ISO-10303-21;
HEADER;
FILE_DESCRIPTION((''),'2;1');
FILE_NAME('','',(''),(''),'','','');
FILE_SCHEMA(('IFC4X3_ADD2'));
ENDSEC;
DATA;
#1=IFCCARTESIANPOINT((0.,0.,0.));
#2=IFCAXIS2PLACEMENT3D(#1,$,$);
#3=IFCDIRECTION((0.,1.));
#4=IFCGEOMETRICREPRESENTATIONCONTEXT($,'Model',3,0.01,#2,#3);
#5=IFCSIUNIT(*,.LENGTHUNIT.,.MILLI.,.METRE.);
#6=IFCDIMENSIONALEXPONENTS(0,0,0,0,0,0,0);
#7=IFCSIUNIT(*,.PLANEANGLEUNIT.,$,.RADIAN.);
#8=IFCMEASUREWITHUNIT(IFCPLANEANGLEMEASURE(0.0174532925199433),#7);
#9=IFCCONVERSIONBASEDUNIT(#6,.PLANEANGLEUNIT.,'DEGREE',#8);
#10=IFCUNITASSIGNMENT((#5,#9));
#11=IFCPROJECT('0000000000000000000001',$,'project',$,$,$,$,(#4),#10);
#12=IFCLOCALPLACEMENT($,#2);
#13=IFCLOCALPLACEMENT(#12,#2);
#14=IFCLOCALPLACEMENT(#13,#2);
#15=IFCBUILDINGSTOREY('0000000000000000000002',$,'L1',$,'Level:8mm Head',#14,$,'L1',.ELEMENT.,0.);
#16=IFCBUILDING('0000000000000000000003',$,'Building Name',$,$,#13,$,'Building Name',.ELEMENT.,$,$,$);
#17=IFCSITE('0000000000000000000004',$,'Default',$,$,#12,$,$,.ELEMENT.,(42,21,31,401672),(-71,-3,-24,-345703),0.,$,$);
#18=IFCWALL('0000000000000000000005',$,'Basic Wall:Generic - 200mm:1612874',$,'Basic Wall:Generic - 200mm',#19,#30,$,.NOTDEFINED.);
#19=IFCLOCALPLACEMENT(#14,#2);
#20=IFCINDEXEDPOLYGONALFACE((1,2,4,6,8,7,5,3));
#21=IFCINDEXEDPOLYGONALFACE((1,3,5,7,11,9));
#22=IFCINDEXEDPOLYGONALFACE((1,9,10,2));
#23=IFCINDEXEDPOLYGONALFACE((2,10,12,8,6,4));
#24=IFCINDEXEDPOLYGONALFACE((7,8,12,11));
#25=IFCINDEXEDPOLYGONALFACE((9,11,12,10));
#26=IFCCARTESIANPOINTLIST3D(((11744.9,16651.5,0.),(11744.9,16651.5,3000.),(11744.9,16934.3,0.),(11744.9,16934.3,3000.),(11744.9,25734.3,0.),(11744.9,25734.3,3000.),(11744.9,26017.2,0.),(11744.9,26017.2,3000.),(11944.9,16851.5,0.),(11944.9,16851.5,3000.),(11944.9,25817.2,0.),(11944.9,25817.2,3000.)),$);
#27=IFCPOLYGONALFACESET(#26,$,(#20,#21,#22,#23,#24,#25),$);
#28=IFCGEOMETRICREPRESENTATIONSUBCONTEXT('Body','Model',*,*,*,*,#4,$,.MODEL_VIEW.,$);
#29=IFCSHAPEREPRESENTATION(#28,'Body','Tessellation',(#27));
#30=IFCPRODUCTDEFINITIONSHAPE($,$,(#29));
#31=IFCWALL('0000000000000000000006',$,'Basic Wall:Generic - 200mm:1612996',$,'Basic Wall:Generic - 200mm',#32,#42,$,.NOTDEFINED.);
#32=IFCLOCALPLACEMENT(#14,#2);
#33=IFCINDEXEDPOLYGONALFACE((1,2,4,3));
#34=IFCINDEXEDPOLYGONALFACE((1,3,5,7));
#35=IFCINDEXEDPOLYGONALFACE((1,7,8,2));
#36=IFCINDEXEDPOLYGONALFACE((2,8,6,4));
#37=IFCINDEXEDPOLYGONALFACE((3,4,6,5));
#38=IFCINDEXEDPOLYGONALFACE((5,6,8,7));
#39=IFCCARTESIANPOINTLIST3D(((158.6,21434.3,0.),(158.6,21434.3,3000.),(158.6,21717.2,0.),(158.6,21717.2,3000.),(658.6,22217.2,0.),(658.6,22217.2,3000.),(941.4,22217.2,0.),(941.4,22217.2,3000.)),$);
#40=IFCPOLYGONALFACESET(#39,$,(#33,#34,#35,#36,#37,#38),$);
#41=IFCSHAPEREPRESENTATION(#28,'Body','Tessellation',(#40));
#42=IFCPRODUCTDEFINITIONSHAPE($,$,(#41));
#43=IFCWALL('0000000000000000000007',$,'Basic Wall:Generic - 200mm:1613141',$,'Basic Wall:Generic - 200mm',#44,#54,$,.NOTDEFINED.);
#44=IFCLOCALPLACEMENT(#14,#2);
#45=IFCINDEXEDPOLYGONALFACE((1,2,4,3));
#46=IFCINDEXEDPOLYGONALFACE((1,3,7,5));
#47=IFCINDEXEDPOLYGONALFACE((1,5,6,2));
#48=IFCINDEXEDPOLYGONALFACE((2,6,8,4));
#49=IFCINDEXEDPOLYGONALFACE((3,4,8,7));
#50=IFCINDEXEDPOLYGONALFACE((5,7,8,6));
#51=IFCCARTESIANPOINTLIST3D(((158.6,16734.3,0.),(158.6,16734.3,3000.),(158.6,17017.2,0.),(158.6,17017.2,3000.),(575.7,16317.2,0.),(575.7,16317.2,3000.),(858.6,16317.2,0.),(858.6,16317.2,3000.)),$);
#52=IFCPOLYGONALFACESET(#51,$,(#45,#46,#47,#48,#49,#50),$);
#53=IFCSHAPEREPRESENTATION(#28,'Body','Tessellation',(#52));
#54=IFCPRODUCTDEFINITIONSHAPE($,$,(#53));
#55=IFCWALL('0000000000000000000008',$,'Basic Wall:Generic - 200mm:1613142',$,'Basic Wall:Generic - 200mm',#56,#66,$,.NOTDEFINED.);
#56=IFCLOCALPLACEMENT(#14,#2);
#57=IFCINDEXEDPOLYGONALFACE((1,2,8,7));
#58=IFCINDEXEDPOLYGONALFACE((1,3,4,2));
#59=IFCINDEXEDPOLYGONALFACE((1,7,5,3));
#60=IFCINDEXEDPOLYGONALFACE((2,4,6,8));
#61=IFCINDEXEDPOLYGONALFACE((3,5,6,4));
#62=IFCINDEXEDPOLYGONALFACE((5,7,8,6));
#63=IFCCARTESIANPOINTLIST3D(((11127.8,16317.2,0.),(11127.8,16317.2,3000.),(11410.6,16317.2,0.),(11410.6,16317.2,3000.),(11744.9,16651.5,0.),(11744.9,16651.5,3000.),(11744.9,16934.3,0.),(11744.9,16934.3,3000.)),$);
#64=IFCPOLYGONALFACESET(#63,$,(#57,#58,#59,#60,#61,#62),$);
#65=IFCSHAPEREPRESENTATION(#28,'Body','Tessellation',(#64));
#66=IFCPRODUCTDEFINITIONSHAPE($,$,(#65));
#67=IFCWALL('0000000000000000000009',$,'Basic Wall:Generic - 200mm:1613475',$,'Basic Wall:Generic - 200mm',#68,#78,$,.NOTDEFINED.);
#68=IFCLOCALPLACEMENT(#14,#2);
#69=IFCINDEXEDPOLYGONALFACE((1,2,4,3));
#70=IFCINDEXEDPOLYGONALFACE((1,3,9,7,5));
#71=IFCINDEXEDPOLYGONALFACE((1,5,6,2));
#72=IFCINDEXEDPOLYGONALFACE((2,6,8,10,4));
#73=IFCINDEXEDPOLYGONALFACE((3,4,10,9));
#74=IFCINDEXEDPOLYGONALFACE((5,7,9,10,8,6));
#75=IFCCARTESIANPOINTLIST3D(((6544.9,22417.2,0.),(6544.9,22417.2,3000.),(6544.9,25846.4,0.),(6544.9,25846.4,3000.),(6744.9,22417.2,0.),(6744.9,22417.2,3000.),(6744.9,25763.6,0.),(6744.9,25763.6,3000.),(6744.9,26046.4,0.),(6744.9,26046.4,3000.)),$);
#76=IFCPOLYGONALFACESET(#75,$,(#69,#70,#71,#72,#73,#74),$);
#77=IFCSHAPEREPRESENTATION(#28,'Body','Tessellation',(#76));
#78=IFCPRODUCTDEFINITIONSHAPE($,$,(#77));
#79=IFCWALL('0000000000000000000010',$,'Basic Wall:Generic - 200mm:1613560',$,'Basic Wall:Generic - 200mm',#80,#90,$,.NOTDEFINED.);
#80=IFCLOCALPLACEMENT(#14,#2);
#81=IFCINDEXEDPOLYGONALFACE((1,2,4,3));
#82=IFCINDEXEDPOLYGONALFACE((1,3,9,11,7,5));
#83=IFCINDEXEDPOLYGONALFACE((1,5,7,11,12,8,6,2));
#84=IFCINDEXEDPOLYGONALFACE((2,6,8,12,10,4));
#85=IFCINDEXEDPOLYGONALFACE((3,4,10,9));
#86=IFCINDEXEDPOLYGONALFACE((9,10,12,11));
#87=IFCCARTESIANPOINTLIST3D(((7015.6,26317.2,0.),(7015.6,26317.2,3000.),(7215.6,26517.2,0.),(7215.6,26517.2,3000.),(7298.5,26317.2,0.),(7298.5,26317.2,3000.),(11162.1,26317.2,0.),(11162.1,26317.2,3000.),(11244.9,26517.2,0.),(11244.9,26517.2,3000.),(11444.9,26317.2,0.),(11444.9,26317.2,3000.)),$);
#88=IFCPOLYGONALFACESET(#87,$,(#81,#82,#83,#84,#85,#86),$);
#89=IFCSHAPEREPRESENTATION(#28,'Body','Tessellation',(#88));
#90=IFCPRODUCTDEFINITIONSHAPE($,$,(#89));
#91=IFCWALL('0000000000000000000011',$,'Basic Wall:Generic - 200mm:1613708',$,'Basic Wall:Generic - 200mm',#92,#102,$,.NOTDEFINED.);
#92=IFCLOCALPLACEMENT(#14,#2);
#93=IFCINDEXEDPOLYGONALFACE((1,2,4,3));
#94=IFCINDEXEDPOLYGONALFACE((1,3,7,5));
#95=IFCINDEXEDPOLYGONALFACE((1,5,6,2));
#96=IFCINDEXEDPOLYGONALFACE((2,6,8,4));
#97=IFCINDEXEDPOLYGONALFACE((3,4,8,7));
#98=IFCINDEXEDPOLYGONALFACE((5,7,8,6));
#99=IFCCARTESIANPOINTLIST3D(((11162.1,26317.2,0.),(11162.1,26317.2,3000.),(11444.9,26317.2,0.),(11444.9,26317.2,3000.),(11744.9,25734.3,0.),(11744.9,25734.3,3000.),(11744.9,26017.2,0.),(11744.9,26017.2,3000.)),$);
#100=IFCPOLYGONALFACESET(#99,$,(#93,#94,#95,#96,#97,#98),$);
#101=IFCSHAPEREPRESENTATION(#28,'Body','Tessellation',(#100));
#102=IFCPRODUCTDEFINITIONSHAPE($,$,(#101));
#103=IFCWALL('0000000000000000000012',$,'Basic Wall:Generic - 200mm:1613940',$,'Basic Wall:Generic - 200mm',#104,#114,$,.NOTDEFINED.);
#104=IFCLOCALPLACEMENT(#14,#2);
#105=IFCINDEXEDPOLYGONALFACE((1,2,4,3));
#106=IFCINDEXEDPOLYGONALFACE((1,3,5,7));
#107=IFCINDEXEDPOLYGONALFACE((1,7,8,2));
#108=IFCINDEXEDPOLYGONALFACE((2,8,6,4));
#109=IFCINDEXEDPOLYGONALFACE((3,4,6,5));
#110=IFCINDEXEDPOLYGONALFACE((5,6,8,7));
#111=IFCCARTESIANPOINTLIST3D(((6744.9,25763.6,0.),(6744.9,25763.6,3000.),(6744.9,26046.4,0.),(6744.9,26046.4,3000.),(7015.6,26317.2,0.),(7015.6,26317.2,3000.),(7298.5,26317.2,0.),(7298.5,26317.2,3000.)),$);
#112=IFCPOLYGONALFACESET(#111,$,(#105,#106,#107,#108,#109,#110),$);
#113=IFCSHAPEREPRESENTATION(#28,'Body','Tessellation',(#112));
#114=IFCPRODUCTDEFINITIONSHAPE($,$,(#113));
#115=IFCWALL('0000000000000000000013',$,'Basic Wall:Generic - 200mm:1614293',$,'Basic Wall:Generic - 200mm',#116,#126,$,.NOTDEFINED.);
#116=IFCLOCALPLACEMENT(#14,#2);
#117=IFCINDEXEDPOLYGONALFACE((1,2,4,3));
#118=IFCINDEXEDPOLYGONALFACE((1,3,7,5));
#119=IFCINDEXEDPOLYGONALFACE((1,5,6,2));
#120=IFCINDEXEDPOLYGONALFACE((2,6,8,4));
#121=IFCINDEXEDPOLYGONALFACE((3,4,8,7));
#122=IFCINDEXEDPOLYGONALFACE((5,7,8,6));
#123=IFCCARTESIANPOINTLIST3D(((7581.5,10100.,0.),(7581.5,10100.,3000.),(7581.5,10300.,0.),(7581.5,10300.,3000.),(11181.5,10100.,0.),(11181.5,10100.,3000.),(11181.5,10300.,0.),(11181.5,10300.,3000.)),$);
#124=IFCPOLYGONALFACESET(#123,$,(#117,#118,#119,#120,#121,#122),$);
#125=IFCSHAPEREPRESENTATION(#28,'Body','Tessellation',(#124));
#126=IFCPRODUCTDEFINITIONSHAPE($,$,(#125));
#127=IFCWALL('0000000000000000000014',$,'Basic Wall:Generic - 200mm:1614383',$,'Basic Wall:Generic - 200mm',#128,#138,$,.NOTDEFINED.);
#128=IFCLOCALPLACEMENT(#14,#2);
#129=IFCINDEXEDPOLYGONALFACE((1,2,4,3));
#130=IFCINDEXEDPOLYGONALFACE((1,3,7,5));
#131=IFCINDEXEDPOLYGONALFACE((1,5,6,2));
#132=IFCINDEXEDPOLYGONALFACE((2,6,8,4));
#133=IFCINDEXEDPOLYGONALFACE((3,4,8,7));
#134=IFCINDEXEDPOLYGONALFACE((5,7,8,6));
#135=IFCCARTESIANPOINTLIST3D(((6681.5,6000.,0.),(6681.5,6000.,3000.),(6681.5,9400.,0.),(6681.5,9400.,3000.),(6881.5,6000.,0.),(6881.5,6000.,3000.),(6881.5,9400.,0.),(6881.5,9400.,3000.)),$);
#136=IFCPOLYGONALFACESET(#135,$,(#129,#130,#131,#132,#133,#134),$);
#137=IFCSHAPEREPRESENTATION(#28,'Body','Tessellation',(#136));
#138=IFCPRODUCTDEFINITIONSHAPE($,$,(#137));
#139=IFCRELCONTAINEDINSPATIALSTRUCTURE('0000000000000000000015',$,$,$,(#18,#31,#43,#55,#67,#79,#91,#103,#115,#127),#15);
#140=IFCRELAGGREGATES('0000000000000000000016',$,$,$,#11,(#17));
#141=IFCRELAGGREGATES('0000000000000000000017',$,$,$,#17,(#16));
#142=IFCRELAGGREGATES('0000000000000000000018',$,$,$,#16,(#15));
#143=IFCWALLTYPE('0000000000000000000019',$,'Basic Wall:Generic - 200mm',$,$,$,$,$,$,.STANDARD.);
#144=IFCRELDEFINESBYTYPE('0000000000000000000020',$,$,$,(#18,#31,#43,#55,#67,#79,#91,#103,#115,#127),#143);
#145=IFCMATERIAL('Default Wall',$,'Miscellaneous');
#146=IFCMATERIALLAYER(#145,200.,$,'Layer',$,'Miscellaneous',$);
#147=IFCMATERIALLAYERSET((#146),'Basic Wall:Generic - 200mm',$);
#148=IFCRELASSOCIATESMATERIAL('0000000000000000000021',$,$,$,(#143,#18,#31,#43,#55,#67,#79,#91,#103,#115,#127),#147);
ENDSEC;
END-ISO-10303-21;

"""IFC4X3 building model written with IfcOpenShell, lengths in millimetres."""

from ifc_helpers import new_model, entity, si_unit, converted_unit, direction, frame, frame_2d, origin, place, context, subcontext, project, spatial, polyline, rectangle, outline, extrude, material, layer, layer_set, type_object, element, save


model = new_model("IFC4X3")

# Units and contexts
model_context = context("Model", 3, precision=0.01, world=origin(), true_north=direction((0.0, 1.0)))
body_context = subcontext(model_context, "Body", "Model", "MODEL_VIEW")
ifc_project = project(units=[si_unit("LENGTHUNIT", "METRE", prefix="MILLI"), converted_unit("PLANEANGLEUNIT", "DEGREE", entity("IfcPlaneAngleMeasure", 0.0174532925199433), si_unit("PLANEANGLEUNIT", "RADIAN"), dimensions=[0, 0, 0, 0, 0, 0, 0])], contexts=[model_context])

# Site, building, storey
site_placement = place(None, origin())
site = spatial("IfcSite", under=ifc_project, at=site_placement, Name="Default", CompositionType="ELEMENT", RefLatitude=(42, 21, 31, 401672), RefLongitude=(-71, -3, -24, -345703), RefElevation=0.0)
building_placement = place(site_placement, origin())
building = spatial("IfcBuilding", under=site, at=building_placement, Name="Building Name", LongName="Building Name", CompositionType="ELEMENT")
storey_placement = place(building_placement, origin())
storey = spatial("IfcBuildingStorey", under=building, at=storey_placement, Name="L1", ObjectType="Level:8mm Head", LongName="L1", CompositionType="ELEMENT", Elevation=0.0)

# Walls
ifc_material = material(Name="Default Wall", Category="Miscellaneous")
ifc_layer = layer(ifc_material, 200.0, Name="Layer", Category="Miscellaneous")
ifc_layer_set = layer_set([ifc_layer], Name="Basic Wall:Generic - 200mm")
wall_type = type_object("IfcWallType", Name="Basic Wall:Generic - 200mm", PredefinedType="STANDARD", material=ifc_layer_set)
wall_1_placement = place(storey_placement, frame((11844.9, 16651.5, 0.0), z_axis=(0.0, 0.0, 1.0), x_axis=(0.0, 1.0, 0.0)))
element("IfcWall", 1, at=wall_1_placement, inside=storey, type_object=wall_type, material=ifc_layer_set, Name="Basic Wall:Generic - 200mm:1612874", ObjectType="Basic Wall:Generic - 200mm", PredefinedType="NOTDEFINED", context=body_context, shape_type="SweptSolid", body=[
    extrude(outline(polyline([(9165.7, -100.0), (9365.7, 100.0), (9082.8, 100.0), (282.8, 100.0), (0.0, 100.0), (200.0, -100.0), (9165.7, -100.0)])), origin(), (0.0, 0.0, 1.0), 3000.0),
])
wall_2_placement = place(storey_placement, frame((870.7, 22287.9, 0.0), z_axis=(0.0, 0.0, 1.0), x_axis=(-0.707107, -0.707107, 0.0)))
element("IfcWall", 2, at=wall_2_placement, inside=storey, type_object=wall_type, material=ifc_layer_set, Name="Basic Wall:Generic - 200mm:1612996", ObjectType="Basic Wall:Generic - 200mm", PredefinedType="NOTDEFINED", context=body_context, shape_type="SweptSolid", body=[
    extrude(outline(polyline([(907.1, -100.0), (1107.1, 100.0), (0.0, 100.0), (200.0, -100.0), (907.1, -100.0)])), origin(), (0.0, 0.0, 1.0), 3000.0),
])
wall_3_placement = place(storey_placement, frame((787.9, 16246.4, 0.0), z_axis=(0.0, 0.0, 1.0), x_axis=(-0.707107, 0.707107, 0.0)))
element("IfcWall", 3, at=wall_3_placement, inside=storey, type_object=wall_type, material=ifc_layer_set, Name="Basic Wall:Generic - 200mm:1613141", ObjectType="Basic Wall:Generic - 200mm", PredefinedType="NOTDEFINED", context=body_context, shape_type="SweptSolid", body=[
    extrude(outline(polyline([(989.9, -100.0), (789.9, 100.0), (200.0, 100.0), (0.0, -100.0), (989.9, -100.0)])), origin(), (0.0, 0.0, 1.0), 3000.0),
])
wall_4_placement = place(storey_placement, frame((11198.5, 16246.4, 0.0), z_axis=(0.0, 0.0, 1.0), x_axis=(0.707107, 0.707107, 0.0)))
element("IfcWall", 4, at=wall_4_placement, inside=storey, type_object=wall_type, material=ifc_layer_set, Name="Basic Wall:Generic - 200mm:1613142", ObjectType="Basic Wall:Generic - 200mm", PredefinedType="NOTDEFINED", context=body_context, shape_type="SweptSolid", body=[
    extrude(outline(polyline([(672.8, -100.0), (872.8, 100.0), (0.0, 100.0), (200.0, -100.0), (672.8, -100.0)])), origin(), (0.0, 0.0, 1.0), 3000.0),
])
wall_5_placement = place(storey_placement, frame((6644.9, 22417.2, 0.0), z_axis=(0.0, 0.0, 1.0), x_axis=(0.0, 1.0, 0.0)))
element("IfcWall", 5, at=wall_5_placement, inside=storey, type_object=wall_type, material=ifc_layer_set, Name="Basic Wall:Generic - 200mm:1613475", ObjectType="Basic Wall:Generic - 200mm", PredefinedType="NOTDEFINED", context=body_context, shape_type="SweptSolid", body=[
    extrude(outline(polyline([(3629.3, -100.0), (3429.3, 100.0), (0.0, 100.0), (0.0, -100.0), (3346.4, -100.0), (3629.3, -100.0)])), origin(), (0.0, 0.0, 1.0), 3000.0),
])
wall_6_placement = place(storey_placement, frame((7015.6, 26417.2, 0.0)))
element("IfcWall", 6, at=wall_6_placement, inside=storey, type_object=wall_type, material=ifc_layer_set, Name="Basic Wall:Generic - 200mm:1613560", ObjectType="Basic Wall:Generic - 200mm", PredefinedType="NOTDEFINED", context=body_context, shape_type="SweptSolid", body=[
    extrude(outline(polyline([(4429.3, -100.0), (4229.3, 100.0), (200.0, 100.0), (0.0, -100.0), (282.8, -100.0), (4146.4, -100.0), (4429.3, -100.0)])), origin(), (0.0, 0.0, 1.0), 3000.0),
])
wall_7_placement = place(storey_placement, frame((11232.8, 26387.9, 0.0), z_axis=(0.0, 0.0, 1.0), x_axis=(0.707107, -0.707107, 0.0)))
element("IfcWall", 7, at=wall_7_placement, inside=storey, type_object=wall_type, material=ifc_layer_set, Name="Basic Wall:Generic - 200mm:1613708", ObjectType="Basic Wall:Generic - 200mm", PredefinedType="NOTDEFINED", context=body_context, shape_type="SweptSolid", body=[
    extrude(outline(polyline([(824.3, -100.0), (624.3, 100.0), (200.0, 100.0), (0.0, -100.0), (824.3, -100.0)])), origin(), (0.0, 0.0, 1.0), 3000.0),
])
wall_8_placement = place(storey_placement, frame((7227.8, 26387.9, 0.0), z_axis=(0.0, 0.0, 1.0), x_axis=(-0.707107, -0.707107, 0.0)))
element("IfcWall", 8, at=wall_8_placement, inside=storey, type_object=wall_type, material=ifc_layer_set, Name="Basic Wall:Generic - 200mm:1613940", ObjectType="Basic Wall:Generic - 200mm", PredefinedType="NOTDEFINED", context=body_context, shape_type="SweptSolid", body=[
    extrude(outline(polyline([(582.8, -100.0), (782.8, 100.0), (0.0, 100.0), (200.0, -100.0), (582.8, -100.0)])), origin(), (0.0, 0.0, 1.0), 3000.0),
])
wall_9_placement = place(storey_placement, frame((11181.5, 10200.0, 0.0), z_axis=(0.0, 0.0, 1.0), x_axis=(-1.0, 0.0, 0.0)))
element("IfcWall", 9, at=wall_9_placement, inside=storey, type_object=wall_type, material=ifc_layer_set, Name="Basic Wall:Generic - 200mm:1614293", ObjectType="Basic Wall:Generic - 200mm", PredefinedType="NOTDEFINED", context=body_context, shape_type="SweptSolid", body=[
    extrude(rectangle(XDim=3600.0, YDim=200.0, at=frame_2d((1800.0, 0.0), x_axis=(-1.0, 0.0))), origin(), (0.0, 0.0, 1.0), 3000.0),
])
wall_10_placement = place(storey_placement, frame((6781.5, 9400.0, 0.0), z_axis=(0.0, 0.0, 1.0), x_axis=(0.0, -1.0, 0.0)))
element("IfcWall", 10, at=wall_10_placement, inside=storey, type_object=wall_type, material=ifc_layer_set, Name="Basic Wall:Generic - 200mm:1614383", ObjectType="Basic Wall:Generic - 200mm", PredefinedType="NOTDEFINED", context=body_context, shape_type="SweptSolid", body=[
    extrude(rectangle(XDim=3400.0, YDim=200.0, at=frame_2d((1700.0, 0.0), x_axis=(-1.0, 0.0))), origin(), (0.0, 0.0, 1.0), 3000.0),
])

save(model, "model.ifc")
